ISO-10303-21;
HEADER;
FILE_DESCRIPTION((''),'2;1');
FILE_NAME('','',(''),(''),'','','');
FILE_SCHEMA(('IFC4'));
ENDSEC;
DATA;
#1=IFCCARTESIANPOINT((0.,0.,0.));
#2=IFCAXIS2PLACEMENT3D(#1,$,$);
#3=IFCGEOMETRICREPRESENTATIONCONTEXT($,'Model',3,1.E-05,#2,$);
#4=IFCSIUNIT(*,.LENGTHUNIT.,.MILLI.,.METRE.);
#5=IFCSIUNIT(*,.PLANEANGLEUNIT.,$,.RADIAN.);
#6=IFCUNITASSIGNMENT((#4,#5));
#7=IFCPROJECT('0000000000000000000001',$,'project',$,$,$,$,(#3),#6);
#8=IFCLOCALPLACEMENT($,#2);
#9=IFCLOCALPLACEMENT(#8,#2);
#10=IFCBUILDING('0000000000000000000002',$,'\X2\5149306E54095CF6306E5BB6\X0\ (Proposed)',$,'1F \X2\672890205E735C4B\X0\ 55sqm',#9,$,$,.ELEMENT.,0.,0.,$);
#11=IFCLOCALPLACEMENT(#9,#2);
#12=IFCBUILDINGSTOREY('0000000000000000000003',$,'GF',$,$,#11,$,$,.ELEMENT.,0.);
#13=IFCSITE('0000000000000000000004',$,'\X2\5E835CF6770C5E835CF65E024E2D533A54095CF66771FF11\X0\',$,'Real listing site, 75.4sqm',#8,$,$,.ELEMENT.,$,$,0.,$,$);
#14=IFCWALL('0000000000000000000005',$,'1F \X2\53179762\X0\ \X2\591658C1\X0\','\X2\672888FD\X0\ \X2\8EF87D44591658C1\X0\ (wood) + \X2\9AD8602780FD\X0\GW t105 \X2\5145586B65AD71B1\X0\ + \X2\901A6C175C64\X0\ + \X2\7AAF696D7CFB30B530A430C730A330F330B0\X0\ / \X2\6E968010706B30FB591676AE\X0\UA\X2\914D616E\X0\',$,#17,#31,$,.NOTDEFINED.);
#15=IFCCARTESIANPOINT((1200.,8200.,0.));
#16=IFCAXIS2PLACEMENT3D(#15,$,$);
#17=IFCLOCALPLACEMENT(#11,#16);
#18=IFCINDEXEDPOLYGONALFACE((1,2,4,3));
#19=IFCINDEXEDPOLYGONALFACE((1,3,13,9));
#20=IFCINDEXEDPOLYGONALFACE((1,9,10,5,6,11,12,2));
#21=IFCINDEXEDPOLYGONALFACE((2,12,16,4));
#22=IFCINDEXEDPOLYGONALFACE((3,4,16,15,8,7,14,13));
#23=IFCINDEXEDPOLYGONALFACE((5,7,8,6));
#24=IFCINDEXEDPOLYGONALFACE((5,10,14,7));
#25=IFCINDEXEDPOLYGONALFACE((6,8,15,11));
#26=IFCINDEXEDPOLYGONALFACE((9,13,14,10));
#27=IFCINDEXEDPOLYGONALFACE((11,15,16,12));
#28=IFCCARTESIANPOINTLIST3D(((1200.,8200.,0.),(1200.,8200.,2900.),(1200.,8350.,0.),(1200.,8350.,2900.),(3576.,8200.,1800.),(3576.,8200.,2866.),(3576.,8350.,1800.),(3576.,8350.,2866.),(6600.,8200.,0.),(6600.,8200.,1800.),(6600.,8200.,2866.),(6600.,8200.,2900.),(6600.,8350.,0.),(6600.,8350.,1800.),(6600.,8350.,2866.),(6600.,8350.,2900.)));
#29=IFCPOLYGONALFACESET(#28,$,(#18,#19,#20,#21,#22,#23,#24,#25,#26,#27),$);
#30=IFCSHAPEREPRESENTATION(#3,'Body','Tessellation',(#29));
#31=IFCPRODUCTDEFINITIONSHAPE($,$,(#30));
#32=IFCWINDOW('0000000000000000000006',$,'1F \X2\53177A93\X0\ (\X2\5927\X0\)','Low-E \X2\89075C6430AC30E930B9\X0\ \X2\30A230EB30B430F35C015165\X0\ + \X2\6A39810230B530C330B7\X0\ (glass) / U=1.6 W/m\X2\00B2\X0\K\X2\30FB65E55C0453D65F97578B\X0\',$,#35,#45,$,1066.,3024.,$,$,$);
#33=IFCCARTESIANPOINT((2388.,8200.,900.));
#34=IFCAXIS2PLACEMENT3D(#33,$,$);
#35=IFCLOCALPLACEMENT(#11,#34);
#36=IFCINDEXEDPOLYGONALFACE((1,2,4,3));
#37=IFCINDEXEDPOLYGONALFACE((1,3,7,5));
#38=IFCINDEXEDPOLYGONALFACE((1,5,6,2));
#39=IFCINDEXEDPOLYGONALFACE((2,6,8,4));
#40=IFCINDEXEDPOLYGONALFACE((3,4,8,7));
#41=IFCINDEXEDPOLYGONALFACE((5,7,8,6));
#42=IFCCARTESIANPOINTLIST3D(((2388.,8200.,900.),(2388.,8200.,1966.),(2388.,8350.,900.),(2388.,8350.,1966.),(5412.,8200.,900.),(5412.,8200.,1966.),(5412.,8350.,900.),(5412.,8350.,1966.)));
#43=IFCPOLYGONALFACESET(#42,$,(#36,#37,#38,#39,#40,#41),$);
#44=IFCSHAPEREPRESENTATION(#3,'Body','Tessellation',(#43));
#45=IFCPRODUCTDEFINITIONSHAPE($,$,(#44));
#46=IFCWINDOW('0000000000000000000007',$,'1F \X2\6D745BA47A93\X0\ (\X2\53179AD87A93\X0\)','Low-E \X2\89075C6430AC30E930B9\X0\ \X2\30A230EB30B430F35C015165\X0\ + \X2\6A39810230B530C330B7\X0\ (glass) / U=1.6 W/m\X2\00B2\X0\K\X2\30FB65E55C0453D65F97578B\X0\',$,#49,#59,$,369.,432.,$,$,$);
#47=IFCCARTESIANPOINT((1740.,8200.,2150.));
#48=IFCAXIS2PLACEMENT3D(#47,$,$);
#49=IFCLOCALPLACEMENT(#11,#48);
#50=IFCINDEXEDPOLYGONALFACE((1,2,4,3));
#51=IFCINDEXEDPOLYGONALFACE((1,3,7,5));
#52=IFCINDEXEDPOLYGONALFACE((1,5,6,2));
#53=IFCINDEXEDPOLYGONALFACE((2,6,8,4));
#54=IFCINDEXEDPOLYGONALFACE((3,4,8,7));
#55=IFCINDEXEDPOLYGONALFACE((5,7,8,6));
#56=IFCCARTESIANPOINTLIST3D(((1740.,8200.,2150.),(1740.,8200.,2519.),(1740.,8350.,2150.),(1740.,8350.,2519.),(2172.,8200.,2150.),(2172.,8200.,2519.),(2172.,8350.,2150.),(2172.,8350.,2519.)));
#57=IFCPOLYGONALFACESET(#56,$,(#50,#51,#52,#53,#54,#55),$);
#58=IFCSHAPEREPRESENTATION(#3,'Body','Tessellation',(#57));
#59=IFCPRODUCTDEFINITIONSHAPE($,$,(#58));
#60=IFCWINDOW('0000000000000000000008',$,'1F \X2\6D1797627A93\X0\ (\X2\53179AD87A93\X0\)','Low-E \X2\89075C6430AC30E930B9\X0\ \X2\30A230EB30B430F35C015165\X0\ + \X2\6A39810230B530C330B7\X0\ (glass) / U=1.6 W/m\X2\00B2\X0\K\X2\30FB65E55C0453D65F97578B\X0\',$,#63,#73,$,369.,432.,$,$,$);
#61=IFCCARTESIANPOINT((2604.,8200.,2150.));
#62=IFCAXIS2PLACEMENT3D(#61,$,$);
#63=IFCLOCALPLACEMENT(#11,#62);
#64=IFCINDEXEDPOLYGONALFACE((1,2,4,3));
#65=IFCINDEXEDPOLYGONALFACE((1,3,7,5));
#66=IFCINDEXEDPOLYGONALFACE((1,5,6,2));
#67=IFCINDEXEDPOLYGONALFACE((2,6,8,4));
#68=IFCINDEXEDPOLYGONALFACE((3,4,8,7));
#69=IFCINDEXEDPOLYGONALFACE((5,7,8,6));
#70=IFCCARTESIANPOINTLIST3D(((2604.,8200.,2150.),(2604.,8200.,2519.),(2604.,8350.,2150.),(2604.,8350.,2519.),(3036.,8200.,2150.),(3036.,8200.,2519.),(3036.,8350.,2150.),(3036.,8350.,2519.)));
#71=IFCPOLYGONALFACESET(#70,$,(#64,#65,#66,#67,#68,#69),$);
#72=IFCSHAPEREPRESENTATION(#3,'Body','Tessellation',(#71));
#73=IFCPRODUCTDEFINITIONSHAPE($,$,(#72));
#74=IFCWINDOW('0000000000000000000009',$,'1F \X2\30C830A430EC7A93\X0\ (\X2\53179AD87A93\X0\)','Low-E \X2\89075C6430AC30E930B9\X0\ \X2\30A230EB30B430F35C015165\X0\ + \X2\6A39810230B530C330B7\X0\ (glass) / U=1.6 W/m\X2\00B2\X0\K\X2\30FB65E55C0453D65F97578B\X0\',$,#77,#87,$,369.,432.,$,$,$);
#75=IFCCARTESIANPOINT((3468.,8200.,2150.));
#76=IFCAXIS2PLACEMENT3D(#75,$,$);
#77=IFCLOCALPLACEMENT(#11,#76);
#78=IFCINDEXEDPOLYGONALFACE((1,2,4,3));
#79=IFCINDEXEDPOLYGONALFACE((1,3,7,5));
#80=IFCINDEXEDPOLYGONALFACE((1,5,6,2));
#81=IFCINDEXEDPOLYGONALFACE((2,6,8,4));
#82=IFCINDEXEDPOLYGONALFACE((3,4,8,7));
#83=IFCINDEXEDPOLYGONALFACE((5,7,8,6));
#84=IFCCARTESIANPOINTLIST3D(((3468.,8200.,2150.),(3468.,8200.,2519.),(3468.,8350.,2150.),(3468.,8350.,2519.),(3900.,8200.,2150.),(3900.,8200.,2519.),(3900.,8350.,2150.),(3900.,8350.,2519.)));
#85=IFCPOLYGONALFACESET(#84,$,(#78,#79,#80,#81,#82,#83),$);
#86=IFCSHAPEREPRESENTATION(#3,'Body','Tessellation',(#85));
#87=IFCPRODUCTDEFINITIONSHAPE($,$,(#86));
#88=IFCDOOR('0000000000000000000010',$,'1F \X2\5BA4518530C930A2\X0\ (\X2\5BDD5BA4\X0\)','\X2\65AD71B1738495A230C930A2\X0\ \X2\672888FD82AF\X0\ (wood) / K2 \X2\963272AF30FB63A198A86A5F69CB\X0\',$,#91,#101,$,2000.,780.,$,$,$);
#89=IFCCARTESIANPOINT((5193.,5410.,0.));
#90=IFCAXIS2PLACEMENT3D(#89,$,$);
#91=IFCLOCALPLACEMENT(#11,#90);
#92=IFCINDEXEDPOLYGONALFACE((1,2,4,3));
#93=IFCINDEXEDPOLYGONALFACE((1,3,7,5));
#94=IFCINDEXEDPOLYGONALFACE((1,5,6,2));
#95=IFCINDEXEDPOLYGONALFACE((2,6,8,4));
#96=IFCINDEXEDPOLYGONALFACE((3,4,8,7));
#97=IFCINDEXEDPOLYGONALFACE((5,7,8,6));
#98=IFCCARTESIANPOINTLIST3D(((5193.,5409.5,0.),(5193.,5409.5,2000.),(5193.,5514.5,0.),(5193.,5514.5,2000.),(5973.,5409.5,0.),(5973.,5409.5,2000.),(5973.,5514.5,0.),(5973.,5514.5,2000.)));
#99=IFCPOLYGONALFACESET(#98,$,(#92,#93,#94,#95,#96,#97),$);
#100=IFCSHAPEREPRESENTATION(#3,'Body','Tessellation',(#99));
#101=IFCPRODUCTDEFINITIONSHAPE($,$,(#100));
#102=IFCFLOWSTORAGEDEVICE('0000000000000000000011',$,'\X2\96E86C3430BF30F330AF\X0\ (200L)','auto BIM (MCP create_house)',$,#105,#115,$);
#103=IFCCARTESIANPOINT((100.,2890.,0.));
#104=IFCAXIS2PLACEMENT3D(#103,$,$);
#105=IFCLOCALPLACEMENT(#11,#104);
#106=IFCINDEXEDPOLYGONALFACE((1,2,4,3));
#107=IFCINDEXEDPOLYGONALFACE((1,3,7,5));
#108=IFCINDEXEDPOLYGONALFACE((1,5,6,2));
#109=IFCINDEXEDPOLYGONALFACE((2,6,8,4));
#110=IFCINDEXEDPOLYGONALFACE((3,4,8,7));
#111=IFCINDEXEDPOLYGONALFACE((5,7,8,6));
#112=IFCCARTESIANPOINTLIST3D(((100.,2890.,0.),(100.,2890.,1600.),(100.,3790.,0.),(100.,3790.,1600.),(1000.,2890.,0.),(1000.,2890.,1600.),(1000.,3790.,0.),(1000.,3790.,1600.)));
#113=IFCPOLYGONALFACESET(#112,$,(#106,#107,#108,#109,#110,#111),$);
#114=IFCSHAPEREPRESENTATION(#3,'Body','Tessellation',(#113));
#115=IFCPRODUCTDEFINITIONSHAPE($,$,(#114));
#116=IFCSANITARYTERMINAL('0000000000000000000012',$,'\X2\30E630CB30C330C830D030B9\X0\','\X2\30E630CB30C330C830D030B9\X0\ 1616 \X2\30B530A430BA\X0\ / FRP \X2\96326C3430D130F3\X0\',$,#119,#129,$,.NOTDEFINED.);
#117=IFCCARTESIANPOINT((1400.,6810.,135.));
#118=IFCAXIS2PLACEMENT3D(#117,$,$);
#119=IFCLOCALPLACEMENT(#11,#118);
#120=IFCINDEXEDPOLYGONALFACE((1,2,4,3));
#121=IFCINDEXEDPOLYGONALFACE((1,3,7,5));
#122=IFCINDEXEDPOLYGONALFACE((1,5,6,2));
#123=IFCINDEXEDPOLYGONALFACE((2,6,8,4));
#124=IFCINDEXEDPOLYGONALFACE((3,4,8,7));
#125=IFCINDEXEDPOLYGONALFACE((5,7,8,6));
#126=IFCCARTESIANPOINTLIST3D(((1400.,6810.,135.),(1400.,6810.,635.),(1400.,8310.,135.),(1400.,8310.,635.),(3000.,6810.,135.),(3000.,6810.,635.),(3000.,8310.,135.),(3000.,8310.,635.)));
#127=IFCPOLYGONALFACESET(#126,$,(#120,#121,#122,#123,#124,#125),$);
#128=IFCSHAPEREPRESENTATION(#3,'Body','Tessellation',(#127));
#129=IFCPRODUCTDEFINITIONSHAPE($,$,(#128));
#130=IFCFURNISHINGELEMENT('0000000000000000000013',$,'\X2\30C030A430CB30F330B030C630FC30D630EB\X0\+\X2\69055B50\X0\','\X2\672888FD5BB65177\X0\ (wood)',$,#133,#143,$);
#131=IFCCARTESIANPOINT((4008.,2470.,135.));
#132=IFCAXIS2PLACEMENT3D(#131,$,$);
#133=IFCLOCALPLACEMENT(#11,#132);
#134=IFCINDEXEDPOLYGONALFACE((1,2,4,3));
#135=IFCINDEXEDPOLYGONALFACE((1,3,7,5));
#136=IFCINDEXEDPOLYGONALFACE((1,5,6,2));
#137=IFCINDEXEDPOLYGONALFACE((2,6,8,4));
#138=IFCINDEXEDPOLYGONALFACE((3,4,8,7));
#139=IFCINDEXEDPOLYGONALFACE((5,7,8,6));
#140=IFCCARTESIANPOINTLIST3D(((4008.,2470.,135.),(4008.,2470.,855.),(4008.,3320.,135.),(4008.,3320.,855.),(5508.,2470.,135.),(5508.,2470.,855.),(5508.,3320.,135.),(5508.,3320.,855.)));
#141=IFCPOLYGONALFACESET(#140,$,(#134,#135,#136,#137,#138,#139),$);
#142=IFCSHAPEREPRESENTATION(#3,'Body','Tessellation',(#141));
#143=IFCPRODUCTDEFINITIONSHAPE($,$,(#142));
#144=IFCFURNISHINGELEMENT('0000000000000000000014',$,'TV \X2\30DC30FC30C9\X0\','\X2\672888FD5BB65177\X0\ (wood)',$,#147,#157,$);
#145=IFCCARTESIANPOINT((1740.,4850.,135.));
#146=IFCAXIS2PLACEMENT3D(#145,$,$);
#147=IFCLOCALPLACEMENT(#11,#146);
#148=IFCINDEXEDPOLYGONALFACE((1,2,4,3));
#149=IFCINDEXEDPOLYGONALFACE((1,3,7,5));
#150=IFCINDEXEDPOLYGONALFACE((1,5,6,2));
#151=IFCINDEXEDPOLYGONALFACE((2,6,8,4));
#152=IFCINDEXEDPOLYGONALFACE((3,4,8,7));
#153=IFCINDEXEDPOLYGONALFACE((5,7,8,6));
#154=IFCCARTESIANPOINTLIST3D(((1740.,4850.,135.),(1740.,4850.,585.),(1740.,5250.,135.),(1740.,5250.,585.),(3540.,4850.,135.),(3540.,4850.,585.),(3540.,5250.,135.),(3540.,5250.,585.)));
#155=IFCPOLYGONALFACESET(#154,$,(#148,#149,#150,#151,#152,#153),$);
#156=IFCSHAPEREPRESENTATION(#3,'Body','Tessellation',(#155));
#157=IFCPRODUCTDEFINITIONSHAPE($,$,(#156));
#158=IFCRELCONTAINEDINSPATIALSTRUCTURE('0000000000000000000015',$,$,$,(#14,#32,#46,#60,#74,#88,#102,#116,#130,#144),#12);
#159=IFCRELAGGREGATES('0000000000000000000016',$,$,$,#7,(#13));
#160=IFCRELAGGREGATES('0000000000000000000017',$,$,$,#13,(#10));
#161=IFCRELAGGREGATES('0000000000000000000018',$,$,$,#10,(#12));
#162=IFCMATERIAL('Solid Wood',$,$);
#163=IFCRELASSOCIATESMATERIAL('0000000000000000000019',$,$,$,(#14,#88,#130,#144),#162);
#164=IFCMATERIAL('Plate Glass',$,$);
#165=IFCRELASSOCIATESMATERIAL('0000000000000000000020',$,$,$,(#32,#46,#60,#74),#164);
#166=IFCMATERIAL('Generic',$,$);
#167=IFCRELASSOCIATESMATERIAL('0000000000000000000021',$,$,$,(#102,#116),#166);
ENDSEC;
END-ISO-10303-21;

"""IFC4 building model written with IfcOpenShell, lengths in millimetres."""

from ifc_helpers import new_model, si_unit, frame, frame_2d, origin, place, context, project, spatial, rectangle, extrude, material, element, fill, save


model = new_model("IFC4")

# Units and contexts
model_context = context("Model", 3, precision=1e-05, world=origin())
ifc_project = project(units=[si_unit("LENGTHUNIT", "METRE", prefix="MILLI"), si_unit("PLANEANGLEUNIT", "RADIAN")], contexts=[model_context])

# Site, building, storey
site_placement = place(None, origin())
site = spatial("IfcSite", under=ifc_project, at=site_placement, Name="広島県広島市中区吉島東１", ObjectType="Real listing site, 75.4sqm", CompositionType="ELEMENT", RefElevation=0.0)
building_placement = place(site_placement, origin())
building = spatial("IfcBuilding", under=site, at=building_placement, Name="光の吉島の家 (Proposed)", ObjectType="1F 木造平屋 55sqm", CompositionType="ELEMENT", ElevationOfRefHeight=0.0, ElevationOfTerrain=0.0)
storey_placement = place(building_placement, origin())
storey = spatial("IfcBuildingStorey", under=building, at=storey_placement, Name="GF", CompositionType="ELEMENT", Elevation=0.0)

# Wall, openings, windows
ifc_material_1 = material(Name="Solid Wood")
wall_1_placement = place(storey_placement, frame((1200.0, 8200.0, 0.0)))
wall_1 = element("IfcWall", 1, at=wall_1_placement, inside=storey, material=ifc_material_1, Name="1F 北面 外壁", Description="木製 軸組外壁 (wood) + 高性能GW t105 充填断熱 + 通気層 + 窯業系サイディング / 準耐火・外皮UA配慮", PredefinedType="NOTDEFINED", context=model_context, shape_type="SweptSolid", body=[
    extrude(rectangle(XDim=5400.0, YDim=150.0, at=frame_2d((2700.0, 75.0))), frame((1200.0, 8200.0, 0.0)), (0.0, 0.0, 1.0), 2900.0),
])
opening_1_placement = place(storey_placement, frame((2388.0, 8200.0, 900.0)))
opening_1 = element("IfcOpeningElement", 2, at=opening_1_placement, cuts=wall_1, PredefinedType="NOTDEFINED", context=model_context, shape_type="SweptSolid", body=[
    extrude(rectangle(XDim=3024.0, YDim=150.0, at=frame_2d((1512.0, 75.0))), frame((2388.0, 8200.0, 900.0)), (0.0, 0.0, 1.0), 1066.0),
])
opening_2_placement = place(storey_placement, frame((1740.0, 8200.0, 2150.0)))
opening_2 = element("IfcOpeningElement", 3, at=opening_2_placement, cuts=wall_1, PredefinedType="NOTDEFINED", context=model_context, shape_type="SweptSolid", body=[
    extrude(rectangle(XDim=432.0, YDim=150.0, at=frame_2d((216.0, 75.0))), frame((1740.0, 8200.0, 2150.0)), (0.0, 0.0, 1.0), 369.0),
])
opening_3_placement = place(storey_placement, frame((2604.0, 8200.0, 2150.0)))
opening_3 = element("IfcOpeningElement", 4, at=opening_3_placement, cuts=wall_1, PredefinedType="NOTDEFINED", context=model_context, shape_type="SweptSolid", body=[
    extrude(rectangle(XDim=432.0, YDim=150.0, at=frame_2d((216.0, 75.0))), frame((2604.0, 8200.0, 2150.0)), (0.0, 0.0, 1.0), 369.0),
])
opening_4_placement = place(storey_placement, frame((3468.0, 8200.0, 2150.0)))
opening_4 = element("IfcOpeningElement", 5, at=opening_4_placement, cuts=wall_1, PredefinedType="NOTDEFINED", context=model_context, shape_type="SweptSolid", body=[
    extrude(rectangle(XDim=432.0, YDim=150.0, at=frame_2d((216.0, 75.0))), frame((3468.0, 8200.0, 2150.0)), (0.0, 0.0, 1.0), 369.0),
])
ifc_material_2 = material(Name="Plate Glass")
window_1_placement = place(storey_placement, frame((2388.0, 8200.0, 900.0)))
window_1 = element("IfcWindow", 6, at=window_1_placement, inside=storey, material=ifc_material_2, Name="1F 北窓 (大)", Description="Low-E 複層ガラス アルゴン封入 + 樹脂サッシ (glass) / U=1.6 W/m²K・日射取得型", OverallHeight=1066.0, OverallWidth=3024.0, context=model_context, shape_type="SweptSolid", body=[
    extrude(rectangle(XDim=3024.0, YDim=150.0, at=frame_2d((1512.0, 75.0))), frame((2388.0, 8200.0, 900.0)), (0.0, 0.0, 1.0), 1066.0),
])
fill(opening_1, window_1)
window_2_placement = place(storey_placement, frame((1740.0, 8200.0, 2150.0)))
window_2 = element("IfcWindow", 7, at=window_2_placement, inside=storey, material=ifc_material_2, Name="1F 浴室窓 (北高窓)", Description="Low-E 複層ガラス アルゴン封入 + 樹脂サッシ (glass) / U=1.6 W/m²K・日射取得型", OverallHeight=369.0, OverallWidth=432.0, context=model_context, shape_type="SweptSolid", body=[
    extrude(rectangle(XDim=432.0, YDim=150.0, at=frame_2d((216.0, 75.0))), frame((1740.0, 8200.0, 2150.0)), (0.0, 0.0, 1.0), 369.0),
])
fill(opening_2, window_2)
window_3_placement = place(storey_placement, frame((2604.0, 8200.0, 2150.0)))
window_3 = element("IfcWindow", 8, at=window_3_placement, inside=storey, material=ifc_material_2, Name="1F 洗面窓 (北高窓)", Description="Low-E 複層ガラス アルゴン封入 + 樹脂サッシ (glass) / U=1.6 W/m²K・日射取得型", OverallHeight=369.0, OverallWidth=432.0, context=model_context, shape_type="SweptSolid", body=[
    extrude(rectangle(XDim=432.0, YDim=150.0, at=frame_2d((216.0, 75.0))), frame((2604.0, 8200.0, 2150.0)), (0.0, 0.0, 1.0), 369.0),
])
fill(opening_3, window_3)
window_4_placement = place(storey_placement, frame((3468.0, 8200.0, 2150.0)))
window_4 = element("IfcWindow", 9, at=window_4_placement, inside=storey, material=ifc_material_2, Name="1F トイレ窓 (北高窓)", Description="Low-E 複層ガラス アルゴン封入 + 樹脂サッシ (glass) / U=1.6 W/m²K・日射取得型", OverallHeight=369.0, OverallWidth=432.0, context=model_context, shape_type="SweptSolid", body=[
    extrude(rectangle(XDim=432.0, YDim=150.0, at=frame_2d((216.0, 75.0))), frame((3468.0, 8200.0, 2150.0)), (0.0, 0.0, 1.0), 369.0),
])
fill(opening_4, window_4)

# Door
door_1_placement = place(storey_placement, frame((5193.0, 5410.0, 0.0)))
element("IfcDoor", 10, at=door_1_placement, inside=storey, material=ifc_material_1, Name="1F 室内ドア (寝室)", Description="断熱玄関ドア 木製芯 (wood) / K2 防犯・採風機構", OverallHeight=2000.0, OverallWidth=780.0, context=model_context, shape_type="SweptSolid", body=[
    extrude(rectangle(XDim=780.0, YDim=105.0, at=frame_2d((390.0, 52.0))), frame((5193.0, 5410.0, 0.0)), (0.0, 0.0, 1.0), 2000.0),
])

# Flow storage device
ifc_material_3 = material(Name="Generic")
flow_storage_device_placement = place(storey_placement, frame((100.0, 2890.0, 0.0)))
element("IfcFlowStorageDevice", 11, at=flow_storage_device_placement, inside=storey, material=ifc_material_3, Name="雨水タンク (200L)", Description="auto BIM (MCP create_house)", context=model_context, shape_type="SweptSolid", body=[
    extrude(rectangle(XDim=900.0, YDim=900.0, at=frame_2d((450.0, 450.0))), frame((100.0, 2890.0, 0.0)), (0.0, 0.0, 1.0), 1600.0),
])

# Sanitary terminal
sanitary_terminal_placement = place(storey_placement, frame((1400.0, 6810.0, 135.0)))
element("IfcSanitaryTerminal", 12, at=sanitary_terminal_placement, inside=storey, material=ifc_material_3, Name="ユニットバス", Description="ユニットバス 1616 サイズ / FRP 防水パン", PredefinedType="NOTDEFINED", context=model_context, shape_type="SweptSolid", body=[
    extrude(rectangle(XDim=1600.0, YDim=1500.0, at=frame_2d((800.0, 750.0))), frame((1400.0, 6810.0, 135.0)), (0.0, 0.0, 1.0), 500.0),
])

# Furnishing elements
furnishing_1_placement = place(storey_placement, frame((4008.0, 2470.0, 135.0)))
element("IfcFurnishingElement", 13, at=furnishing_1_placement, inside=storey, material=ifc_material_1, Name="ダイニングテーブル+椅子", Description="木製家具 (wood)", context=model_context, shape_type="SweptSolid", body=[
    extrude(rectangle(XDim=1500.0, YDim=850.0, at=frame_2d((750.0, 425.0))), frame((4008.0, 2470.0, 135.0)), (0.0, 0.0, 1.0), 720.0),
])
furnishing_2_placement = place(storey_placement, frame((1740.0, 4850.0, 135.0)))
element("IfcFurnishingElement", 14, at=furnishing_2_placement, inside=storey, material=ifc_material_1, Name="TV ボード", Description="木製家具 (wood)", context=model_context, shape_type="SweptSolid", body=[
    extrude(rectangle(XDim=1800.0, YDim=400.0, at=frame_2d((900.0, 200.0))), frame((1740.0, 4850.0, 135.0)), (0.0, 0.0, 1.0), 450.0),
])

save(model, "model.ifc")
